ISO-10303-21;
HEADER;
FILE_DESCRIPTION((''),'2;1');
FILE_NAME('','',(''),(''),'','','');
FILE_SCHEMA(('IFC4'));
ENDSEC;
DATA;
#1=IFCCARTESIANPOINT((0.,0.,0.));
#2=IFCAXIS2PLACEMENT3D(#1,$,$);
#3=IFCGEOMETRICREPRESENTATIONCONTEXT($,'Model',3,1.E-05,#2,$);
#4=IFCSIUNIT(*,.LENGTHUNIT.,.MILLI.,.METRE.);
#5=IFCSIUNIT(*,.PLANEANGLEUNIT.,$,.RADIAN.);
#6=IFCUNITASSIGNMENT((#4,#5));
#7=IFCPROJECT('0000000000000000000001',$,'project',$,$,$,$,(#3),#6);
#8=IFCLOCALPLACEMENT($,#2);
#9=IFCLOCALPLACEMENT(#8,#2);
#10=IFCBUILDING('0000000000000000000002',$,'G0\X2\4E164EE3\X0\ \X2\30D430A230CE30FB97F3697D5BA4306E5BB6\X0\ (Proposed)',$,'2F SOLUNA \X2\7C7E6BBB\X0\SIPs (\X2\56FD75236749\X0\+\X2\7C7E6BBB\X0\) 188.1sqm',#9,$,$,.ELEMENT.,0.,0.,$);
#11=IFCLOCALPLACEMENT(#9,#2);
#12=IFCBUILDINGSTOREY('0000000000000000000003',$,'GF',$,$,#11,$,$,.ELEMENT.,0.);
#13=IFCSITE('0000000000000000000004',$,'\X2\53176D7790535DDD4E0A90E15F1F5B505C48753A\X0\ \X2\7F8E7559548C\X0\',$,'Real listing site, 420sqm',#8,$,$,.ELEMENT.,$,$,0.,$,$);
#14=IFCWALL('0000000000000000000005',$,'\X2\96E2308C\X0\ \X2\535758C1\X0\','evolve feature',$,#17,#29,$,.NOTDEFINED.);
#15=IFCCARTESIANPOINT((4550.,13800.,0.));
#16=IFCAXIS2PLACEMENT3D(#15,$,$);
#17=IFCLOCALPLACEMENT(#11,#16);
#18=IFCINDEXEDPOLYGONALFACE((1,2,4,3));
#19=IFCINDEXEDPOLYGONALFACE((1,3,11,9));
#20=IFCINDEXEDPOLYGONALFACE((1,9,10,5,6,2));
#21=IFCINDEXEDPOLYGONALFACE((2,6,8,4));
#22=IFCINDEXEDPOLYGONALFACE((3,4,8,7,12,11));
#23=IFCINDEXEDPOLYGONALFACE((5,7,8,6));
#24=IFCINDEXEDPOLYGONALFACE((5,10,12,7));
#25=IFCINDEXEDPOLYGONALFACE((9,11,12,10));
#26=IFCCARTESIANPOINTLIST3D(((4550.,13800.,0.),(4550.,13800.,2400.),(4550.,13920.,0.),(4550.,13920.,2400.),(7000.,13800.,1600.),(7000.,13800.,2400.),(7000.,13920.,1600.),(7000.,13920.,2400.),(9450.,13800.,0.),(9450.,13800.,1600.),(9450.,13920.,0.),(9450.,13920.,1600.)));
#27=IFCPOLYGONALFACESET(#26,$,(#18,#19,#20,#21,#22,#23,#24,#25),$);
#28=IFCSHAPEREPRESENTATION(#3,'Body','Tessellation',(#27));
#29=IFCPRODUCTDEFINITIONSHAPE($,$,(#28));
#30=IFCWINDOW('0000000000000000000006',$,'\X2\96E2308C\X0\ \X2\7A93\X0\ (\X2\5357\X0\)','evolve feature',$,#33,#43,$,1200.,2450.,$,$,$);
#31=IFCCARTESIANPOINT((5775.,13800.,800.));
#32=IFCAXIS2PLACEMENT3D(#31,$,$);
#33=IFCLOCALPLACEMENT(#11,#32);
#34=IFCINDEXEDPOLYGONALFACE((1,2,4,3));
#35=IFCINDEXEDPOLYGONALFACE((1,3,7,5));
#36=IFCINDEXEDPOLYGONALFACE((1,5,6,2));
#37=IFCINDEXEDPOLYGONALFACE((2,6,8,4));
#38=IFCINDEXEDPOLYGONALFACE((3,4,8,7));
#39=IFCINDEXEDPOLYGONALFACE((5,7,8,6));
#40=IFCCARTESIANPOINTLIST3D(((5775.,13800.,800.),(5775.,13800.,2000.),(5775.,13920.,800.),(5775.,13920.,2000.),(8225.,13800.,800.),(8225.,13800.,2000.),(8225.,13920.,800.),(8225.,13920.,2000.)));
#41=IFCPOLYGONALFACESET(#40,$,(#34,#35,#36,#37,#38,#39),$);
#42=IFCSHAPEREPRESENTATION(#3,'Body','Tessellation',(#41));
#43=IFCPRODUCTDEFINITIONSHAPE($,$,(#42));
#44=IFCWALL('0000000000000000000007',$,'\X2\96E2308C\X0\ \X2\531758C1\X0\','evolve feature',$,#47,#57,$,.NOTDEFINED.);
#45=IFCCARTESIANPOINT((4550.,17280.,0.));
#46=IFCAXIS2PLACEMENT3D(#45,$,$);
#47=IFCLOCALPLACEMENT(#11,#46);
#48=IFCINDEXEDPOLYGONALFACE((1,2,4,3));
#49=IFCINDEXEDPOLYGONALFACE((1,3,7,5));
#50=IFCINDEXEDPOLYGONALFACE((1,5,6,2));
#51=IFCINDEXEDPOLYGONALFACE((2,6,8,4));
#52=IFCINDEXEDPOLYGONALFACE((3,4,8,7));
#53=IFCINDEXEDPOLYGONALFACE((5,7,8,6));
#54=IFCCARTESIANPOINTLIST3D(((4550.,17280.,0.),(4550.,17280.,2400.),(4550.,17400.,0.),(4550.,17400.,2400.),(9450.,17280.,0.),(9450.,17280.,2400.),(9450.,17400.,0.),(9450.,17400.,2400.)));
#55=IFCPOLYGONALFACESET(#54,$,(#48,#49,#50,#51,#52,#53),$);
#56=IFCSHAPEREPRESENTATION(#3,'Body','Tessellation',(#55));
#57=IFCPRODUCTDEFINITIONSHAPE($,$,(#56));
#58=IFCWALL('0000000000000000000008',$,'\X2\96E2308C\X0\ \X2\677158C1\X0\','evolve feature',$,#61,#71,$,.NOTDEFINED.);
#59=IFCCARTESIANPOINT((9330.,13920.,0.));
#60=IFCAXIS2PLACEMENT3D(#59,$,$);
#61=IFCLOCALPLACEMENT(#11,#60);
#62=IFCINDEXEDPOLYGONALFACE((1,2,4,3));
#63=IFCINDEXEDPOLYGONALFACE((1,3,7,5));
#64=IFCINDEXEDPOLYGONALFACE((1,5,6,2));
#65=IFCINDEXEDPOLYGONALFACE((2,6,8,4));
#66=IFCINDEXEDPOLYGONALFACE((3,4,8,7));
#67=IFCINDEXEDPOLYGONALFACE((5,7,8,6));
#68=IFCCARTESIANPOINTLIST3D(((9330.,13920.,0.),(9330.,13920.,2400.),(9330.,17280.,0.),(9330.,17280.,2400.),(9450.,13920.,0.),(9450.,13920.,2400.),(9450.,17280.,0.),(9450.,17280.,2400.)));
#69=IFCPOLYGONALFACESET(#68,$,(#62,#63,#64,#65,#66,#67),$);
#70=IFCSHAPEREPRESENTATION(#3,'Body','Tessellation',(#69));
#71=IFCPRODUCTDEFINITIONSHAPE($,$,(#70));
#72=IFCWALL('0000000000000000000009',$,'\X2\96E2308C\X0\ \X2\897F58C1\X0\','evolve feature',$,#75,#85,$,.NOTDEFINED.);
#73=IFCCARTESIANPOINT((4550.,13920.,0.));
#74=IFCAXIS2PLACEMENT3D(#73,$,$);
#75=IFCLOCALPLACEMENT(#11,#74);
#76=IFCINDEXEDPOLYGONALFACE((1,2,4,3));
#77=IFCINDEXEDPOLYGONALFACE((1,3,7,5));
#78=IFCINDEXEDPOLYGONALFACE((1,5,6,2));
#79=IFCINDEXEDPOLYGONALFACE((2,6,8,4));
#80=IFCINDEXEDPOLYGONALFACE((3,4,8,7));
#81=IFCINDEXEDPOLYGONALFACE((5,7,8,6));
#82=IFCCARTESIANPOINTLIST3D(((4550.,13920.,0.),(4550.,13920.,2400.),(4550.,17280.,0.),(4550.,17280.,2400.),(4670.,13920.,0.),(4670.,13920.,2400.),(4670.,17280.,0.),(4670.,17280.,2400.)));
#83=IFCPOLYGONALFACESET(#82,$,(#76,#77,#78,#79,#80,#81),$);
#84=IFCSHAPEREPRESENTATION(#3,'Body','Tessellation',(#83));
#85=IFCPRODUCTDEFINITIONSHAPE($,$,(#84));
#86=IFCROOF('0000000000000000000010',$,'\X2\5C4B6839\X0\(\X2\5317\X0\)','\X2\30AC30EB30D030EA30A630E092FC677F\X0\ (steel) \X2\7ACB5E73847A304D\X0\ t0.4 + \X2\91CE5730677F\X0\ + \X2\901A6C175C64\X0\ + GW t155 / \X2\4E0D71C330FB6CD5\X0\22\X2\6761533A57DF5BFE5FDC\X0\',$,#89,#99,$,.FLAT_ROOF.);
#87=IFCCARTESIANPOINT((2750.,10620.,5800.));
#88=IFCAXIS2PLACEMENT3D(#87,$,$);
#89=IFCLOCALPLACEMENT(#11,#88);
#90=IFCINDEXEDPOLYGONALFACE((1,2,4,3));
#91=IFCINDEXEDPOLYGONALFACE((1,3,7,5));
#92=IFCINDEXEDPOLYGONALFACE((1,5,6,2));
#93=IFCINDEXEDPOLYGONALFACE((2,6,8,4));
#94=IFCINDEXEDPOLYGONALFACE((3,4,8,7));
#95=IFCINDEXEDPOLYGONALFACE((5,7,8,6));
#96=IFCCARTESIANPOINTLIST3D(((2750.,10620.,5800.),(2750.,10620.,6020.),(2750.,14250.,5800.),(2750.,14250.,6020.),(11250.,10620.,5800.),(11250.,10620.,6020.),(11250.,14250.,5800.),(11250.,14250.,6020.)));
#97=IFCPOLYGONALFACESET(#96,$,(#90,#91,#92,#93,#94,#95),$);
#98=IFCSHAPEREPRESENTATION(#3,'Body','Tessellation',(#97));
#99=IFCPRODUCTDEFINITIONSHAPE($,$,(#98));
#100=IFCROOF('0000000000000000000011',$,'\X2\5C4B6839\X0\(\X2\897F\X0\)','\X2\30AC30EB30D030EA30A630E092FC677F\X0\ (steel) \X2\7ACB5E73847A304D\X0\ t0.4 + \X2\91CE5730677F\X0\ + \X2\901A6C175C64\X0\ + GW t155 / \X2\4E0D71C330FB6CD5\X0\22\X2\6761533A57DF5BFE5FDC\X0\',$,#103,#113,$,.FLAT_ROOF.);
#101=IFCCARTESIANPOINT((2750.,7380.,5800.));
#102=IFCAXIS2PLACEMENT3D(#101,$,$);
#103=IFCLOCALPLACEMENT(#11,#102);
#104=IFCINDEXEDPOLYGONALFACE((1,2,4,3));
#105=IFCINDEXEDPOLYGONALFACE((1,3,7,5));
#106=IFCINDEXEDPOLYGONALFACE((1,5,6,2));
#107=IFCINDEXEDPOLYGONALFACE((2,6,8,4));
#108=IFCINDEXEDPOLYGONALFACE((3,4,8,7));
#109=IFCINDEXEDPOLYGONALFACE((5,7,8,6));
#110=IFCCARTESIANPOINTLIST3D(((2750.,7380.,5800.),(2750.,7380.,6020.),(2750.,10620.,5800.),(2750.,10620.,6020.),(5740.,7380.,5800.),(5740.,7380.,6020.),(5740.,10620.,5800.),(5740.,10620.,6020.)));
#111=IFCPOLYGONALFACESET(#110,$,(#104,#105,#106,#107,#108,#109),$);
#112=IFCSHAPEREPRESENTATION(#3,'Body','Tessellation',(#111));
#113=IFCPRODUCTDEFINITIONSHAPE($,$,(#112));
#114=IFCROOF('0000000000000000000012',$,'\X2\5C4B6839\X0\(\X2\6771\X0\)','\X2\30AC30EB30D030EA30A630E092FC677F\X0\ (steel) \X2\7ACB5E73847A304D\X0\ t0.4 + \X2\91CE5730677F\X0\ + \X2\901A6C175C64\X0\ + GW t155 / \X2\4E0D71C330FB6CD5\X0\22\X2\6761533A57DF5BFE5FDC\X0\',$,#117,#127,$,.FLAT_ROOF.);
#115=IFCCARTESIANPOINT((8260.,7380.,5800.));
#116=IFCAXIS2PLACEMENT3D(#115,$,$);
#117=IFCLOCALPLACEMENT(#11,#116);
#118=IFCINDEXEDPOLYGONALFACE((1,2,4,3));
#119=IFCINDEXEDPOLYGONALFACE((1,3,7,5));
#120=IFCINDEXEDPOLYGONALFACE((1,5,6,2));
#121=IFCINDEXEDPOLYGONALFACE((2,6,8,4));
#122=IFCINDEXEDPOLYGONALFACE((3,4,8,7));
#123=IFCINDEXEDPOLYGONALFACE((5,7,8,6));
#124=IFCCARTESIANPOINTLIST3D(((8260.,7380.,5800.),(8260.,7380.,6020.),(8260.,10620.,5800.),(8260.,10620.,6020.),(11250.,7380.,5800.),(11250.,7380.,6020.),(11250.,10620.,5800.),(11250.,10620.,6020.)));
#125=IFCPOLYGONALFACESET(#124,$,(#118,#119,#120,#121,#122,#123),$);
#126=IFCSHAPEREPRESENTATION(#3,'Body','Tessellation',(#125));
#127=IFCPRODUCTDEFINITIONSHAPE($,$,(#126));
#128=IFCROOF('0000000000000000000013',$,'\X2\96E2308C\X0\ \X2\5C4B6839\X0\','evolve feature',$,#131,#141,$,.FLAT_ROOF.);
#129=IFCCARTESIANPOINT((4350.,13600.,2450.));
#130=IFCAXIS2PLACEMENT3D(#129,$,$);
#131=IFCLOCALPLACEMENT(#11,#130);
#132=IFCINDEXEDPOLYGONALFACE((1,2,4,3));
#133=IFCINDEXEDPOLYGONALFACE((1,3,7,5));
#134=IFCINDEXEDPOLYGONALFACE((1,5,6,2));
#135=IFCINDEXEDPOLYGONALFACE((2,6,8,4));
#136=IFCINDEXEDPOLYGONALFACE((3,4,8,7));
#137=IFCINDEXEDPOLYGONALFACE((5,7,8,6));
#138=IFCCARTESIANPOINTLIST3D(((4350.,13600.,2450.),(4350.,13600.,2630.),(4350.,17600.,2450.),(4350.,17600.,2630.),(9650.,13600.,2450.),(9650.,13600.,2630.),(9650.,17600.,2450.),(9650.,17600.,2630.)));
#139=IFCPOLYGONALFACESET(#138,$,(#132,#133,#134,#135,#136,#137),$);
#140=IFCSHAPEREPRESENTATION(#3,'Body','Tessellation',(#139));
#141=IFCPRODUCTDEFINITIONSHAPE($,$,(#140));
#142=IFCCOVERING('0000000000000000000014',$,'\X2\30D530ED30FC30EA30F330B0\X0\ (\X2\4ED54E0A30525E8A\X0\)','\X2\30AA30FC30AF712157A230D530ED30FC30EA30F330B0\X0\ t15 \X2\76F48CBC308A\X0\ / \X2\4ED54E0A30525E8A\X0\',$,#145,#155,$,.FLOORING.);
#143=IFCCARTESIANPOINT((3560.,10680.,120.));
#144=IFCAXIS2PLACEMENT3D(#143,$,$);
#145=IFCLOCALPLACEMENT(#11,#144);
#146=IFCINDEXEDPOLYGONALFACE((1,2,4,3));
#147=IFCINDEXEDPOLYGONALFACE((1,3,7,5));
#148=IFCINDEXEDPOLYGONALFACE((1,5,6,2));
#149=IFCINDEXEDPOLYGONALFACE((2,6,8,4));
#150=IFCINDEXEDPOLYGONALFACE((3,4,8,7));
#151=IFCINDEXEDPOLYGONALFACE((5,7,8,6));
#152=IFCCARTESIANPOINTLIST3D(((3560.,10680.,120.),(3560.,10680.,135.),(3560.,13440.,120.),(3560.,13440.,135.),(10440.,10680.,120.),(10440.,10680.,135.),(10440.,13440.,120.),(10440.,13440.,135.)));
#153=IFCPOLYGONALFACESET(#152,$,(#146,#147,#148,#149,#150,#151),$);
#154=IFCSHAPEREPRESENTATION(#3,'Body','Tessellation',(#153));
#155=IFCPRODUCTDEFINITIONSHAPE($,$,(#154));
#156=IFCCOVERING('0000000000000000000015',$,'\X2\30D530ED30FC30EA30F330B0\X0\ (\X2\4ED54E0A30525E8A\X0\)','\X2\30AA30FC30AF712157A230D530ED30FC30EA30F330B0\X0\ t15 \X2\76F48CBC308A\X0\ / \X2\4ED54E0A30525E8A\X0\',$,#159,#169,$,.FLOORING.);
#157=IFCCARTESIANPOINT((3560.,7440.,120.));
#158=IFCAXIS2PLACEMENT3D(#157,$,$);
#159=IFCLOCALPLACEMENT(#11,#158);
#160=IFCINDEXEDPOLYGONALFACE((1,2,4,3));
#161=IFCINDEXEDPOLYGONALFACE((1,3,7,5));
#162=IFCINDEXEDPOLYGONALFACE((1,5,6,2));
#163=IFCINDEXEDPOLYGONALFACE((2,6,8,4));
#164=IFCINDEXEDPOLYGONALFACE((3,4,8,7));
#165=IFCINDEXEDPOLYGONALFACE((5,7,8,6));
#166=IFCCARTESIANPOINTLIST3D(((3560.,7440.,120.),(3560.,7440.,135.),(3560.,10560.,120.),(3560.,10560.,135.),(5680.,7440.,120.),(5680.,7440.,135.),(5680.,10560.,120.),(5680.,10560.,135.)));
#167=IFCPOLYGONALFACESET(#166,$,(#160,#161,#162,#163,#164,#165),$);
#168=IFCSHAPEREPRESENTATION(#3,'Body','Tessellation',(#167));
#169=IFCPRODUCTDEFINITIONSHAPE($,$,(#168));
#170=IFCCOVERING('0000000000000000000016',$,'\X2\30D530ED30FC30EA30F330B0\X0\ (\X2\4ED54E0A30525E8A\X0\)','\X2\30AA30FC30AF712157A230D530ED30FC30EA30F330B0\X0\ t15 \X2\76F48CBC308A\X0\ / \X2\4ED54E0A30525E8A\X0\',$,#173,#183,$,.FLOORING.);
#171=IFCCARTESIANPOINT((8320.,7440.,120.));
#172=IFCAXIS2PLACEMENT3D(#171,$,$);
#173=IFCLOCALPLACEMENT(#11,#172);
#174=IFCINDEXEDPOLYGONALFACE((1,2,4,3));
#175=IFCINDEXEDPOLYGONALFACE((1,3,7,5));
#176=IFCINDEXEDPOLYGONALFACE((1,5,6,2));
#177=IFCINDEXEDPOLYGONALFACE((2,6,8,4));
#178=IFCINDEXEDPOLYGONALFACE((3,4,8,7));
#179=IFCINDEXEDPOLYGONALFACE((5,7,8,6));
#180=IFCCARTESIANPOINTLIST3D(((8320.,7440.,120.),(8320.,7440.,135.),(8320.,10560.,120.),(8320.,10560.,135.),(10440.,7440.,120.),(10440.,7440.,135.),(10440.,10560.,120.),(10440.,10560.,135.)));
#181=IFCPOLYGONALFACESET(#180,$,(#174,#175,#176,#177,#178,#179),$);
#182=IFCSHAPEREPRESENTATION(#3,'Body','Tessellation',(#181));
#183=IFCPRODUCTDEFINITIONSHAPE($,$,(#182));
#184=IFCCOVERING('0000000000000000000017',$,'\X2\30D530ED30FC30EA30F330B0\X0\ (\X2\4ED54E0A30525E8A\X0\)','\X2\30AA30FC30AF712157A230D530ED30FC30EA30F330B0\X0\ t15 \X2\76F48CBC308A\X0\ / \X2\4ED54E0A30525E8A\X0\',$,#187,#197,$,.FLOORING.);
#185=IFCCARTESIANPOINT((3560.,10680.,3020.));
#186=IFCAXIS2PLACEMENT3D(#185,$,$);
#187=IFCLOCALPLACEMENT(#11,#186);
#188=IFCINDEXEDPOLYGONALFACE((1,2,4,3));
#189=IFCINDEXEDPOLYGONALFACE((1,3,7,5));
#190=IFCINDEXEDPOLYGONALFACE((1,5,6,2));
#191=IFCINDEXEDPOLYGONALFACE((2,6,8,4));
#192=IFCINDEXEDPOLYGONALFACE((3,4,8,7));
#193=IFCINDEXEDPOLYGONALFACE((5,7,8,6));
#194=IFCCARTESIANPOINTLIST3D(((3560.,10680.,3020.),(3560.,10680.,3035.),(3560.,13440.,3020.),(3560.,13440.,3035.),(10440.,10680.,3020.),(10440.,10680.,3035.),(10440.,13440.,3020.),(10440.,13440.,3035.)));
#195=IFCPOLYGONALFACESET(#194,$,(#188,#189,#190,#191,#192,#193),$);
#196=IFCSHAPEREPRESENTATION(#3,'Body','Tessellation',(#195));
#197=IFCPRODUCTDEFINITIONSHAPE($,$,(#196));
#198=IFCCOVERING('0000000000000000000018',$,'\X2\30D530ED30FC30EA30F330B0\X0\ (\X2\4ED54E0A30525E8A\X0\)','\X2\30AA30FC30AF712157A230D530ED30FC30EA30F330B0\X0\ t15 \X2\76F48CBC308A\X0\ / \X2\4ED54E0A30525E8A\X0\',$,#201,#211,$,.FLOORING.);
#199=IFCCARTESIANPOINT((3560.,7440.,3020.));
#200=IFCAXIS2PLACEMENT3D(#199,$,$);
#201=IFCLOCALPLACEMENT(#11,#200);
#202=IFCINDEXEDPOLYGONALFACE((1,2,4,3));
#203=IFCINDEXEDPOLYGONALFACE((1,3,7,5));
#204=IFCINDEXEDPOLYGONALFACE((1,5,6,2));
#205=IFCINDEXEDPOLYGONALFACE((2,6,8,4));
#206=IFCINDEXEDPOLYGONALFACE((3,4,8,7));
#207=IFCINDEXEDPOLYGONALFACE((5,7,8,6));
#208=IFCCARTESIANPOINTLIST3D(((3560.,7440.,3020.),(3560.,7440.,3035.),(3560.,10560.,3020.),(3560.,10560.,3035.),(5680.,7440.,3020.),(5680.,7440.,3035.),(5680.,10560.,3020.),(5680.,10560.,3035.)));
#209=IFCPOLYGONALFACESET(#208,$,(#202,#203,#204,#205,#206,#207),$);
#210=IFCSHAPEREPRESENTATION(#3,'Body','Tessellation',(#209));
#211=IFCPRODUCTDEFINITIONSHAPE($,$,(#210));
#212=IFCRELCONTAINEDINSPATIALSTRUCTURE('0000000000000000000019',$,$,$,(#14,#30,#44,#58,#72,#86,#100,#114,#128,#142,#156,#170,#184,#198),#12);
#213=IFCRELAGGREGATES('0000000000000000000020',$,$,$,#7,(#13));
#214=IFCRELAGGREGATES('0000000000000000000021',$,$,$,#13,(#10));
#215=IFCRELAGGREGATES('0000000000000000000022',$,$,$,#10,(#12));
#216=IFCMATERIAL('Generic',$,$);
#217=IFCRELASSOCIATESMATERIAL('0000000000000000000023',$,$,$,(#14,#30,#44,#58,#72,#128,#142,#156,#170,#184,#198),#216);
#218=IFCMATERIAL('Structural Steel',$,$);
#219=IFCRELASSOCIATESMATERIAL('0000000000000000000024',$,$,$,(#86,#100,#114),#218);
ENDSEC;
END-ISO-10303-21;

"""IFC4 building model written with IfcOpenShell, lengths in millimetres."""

from ifc_helpers import new_model, si_unit, frame, frame_2d, origin, place, context, project, spatial, rectangle, extrude, material, element, fill, save


model = new_model("IFC4")

# Units and contexts
model_context = context("Model", 3, precision=1e-05, world=origin())
ifc_project = project(units=[si_unit("LENGTHUNIT", "METRE", prefix="MILLI"), si_unit("PLANEANGLEUNIT", "RADIAN")], contexts=[model_context])

# Site, building, storey
site_placement = place(None, origin())
site = spatial("IfcSite", under=ifc_project, at=site_placement, Name="北海道川上郡弟子屈町 美留和", ObjectType="Real listing site, 420sqm", CompositionType="ELEMENT", RefElevation=0.0)
building_placement = place(site_placement, origin())
building = spatial("IfcBuilding", under=site, at=building_placement, Name="G0世代 ピアノ・音楽室の家 (Proposed)", ObjectType="2F SOLUNA 籾殻SIPs (国産杉+籾殻) 188.1sqm", CompositionType="ELEMENT", ElevationOfRefHeight=0.0, ElevationOfTerrain=0.0)
storey_placement = place(building_placement, origin())
storey = spatial("IfcBuildingStorey", under=building, at=storey_placement, Name="GF", CompositionType="ELEMENT", Elevation=0.0)

# Shared definitions
ifc_material_1 = material(Name="Generic")

# Wall, opening, window
wall_1_placement = place(storey_placement, frame((4550.0, 13800.0, 0.0)))
wall_1 = element("IfcWall", 1, at=wall_1_placement, inside=storey, material=ifc_material_1, Name="離れ 南壁", Description="evolve feature", PredefinedType="NOTDEFINED", context=model_context, shape_type="SweptSolid", body=[
    extrude(rectangle(XDim=4900.0, YDim=120.0, at=frame_2d((2450.0, 60.0))), frame((4550.0, 13800.0, 0.0)), (0.0, 0.0, 1.0), 2400.0),
])
opening_1_placement = place(storey_placement, frame((5775.0, 13800.0, 800.0)))
opening_1 = element("IfcOpeningElement", 2, at=opening_1_placement, cuts=wall_1, PredefinedType="NOTDEFINED", context=model_context, shape_type="SweptSolid", body=[
    extrude(rectangle(XDim=2450.0, YDim=120.0, at=frame_2d((1225.0, 60.0))), frame((5775.0, 13800.0, 800.0)), (0.0, 0.0, 1.0), 1200.0),
])
window_1_placement = place(storey_placement, frame((5775.0, 13800.0, 800.0)))
window_1 = element("IfcWindow", 3, at=window_1_placement, inside=storey, material=ifc_material_1, Name="離れ 窓 (南)", Description="evolve feature", OverallHeight=1200.0, OverallWidth=2450.0, context=model_context, shape_type="SweptSolid", body=[
    extrude(rectangle(XDim=2450.0, YDim=120.0, at=frame_2d((1225.0, 60.0))), frame((5775.0, 13800.0, 800.0)), (0.0, 0.0, 1.0), 1200.0),
])
fill(opening_1, window_1)

# Walls
wall_2_placement = place(storey_placement, frame((4550.0, 17280.0, 0.0)))
element("IfcWall", 4, at=wall_2_placement, inside=storey, material=ifc_material_1, Name="離れ 北壁", Description="evolve feature", PredefinedType="NOTDEFINED", context=model_context, shape_type="SweptSolid", body=[
    extrude(rectangle(XDim=4900.0, YDim=120.0, at=frame_2d((2450.0, 60.0))), frame((4550.0, 17280.0, 0.0)), (0.0, 0.0, 1.0), 2400.0),
])
wall_3_placement = place(storey_placement, frame((9330.0, 13920.0, 0.0)))
element("IfcWall", 5, at=wall_3_placement, inside=storey, material=ifc_material_1, Name="離れ 東壁", Description="evolve feature", PredefinedType="NOTDEFINED", context=model_context, shape_type="SweptSolid", body=[
    extrude(rectangle(XDim=120.0, YDim=3360.0, at=frame_2d((60.0, 1680.0))), frame((9330.0, 13920.0, 0.0)), (0.0, 0.0, 1.0), 2400.0),
])
wall_4_placement = place(storey_placement, frame((4550.0, 13920.0, 0.0)))
element("IfcWall", 6, at=wall_4_placement, inside=storey, material=ifc_material_1, Name="離れ 西壁", Description="evolve feature", PredefinedType="NOTDEFINED", context=model_context, shape_type="SweptSolid", body=[
    extrude(rectangle(XDim=120.0, YDim=3360.0, at=frame_2d((60.0, 1680.0))), frame((4550.0, 13920.0, 0.0)), (0.0, 0.0, 1.0), 2400.0),
])

# Roofs
ifc_material_2 = material(Name="Structural Steel")
for number, where, name in (
    (7, (2750.0, 10620.0, 5800.0), "屋根(北)"),
):
    element("IfcRoof", number, at=place(storey_placement, frame(where)), inside=storey, material=ifc_material_2, Name=name, Description="ガルバリウム鋼板 (steel) 立平葺き t0.4 + 野地板 + 通気層 + GW t155 / 不燃・法22条区域対応", PredefinedType="FLAT_ROOF", context=model_context, shape_type="SweptSolid", body=[
        extrude(rectangle(XDim=8500.0, YDim=3630.0, at=frame_2d((4250.0, 1815.0))), frame((2750.0, 10620.0, 5800.0)), (0.0, 0.0, 1.0), 220.0),
    ])
roof_1_placement = place(storey_placement, frame((2750.0, 7380.0, 5800.0)))
element("IfcRoof", 8, at=roof_1_placement, inside=storey, material=ifc_material_2, Name="屋根(西)", Description="ガルバリウム鋼板 (steel) 立平葺き t0.4 + 野地板 + 通気層 + GW t155 / 不燃・法22条区域対応", PredefinedType="FLAT_ROOF", context=model_context, shape_type="SweptSolid", body=[
    extrude(rectangle(XDim=2990.0, YDim=3240.0, at=frame_2d((1495.0, 1620.0))), frame((2750.0, 7380.0, 5800.0)), (0.0, 0.0, 1.0), 220.0),
])
roof_2_placement = place(storey_placement, frame((8260.0, 7380.0, 5800.0)))
element("IfcRoof", 9, at=roof_2_placement, inside=storey, material=ifc_material_2, Name="屋根(東)", Description="ガルバリウム鋼板 (steel) 立平葺き t0.4 + 野地板 + 通気層 + GW t155 / 不燃・法22条区域対応", PredefinedType="FLAT_ROOF", context=model_context, shape_type="SweptSolid", body=[
    extrude(rectangle(XDim=2990.0, YDim=3240.0, at=frame_2d((1495.0, 1620.0))), frame((8260.0, 7380.0, 5800.0)), (0.0, 0.0, 1.0), 220.0),
])
roof_3_placement = place(storey_placement, frame((4350.0, 13600.0, 2450.0)))
element("IfcRoof", 10, at=roof_3_placement, inside=storey, material=ifc_material_1, Name="離れ 屋根", Description="evolve feature", PredefinedType="FLAT_ROOF", context=model_context, shape_type="SweptSolid", body=[
    extrude(rectangle(XDim=5300.0, YDim=4000.0, at=frame_2d((2650.0, 2000.0))), frame((4350.0, 13600.0, 2450.0)), (0.0, 0.0, 1.0), 180.0),
])

# Coverings
covering_1_placement = place(storey_placement, frame((3560.0, 10680.0, 120.0)))
element("IfcCovering", 11, at=covering_1_placement, inside=storey, material=ifc_material_1, Name="フローリング (仕上げ床)", Description="オーク無垢フローリング t15 直貼り / 仕上げ床", PredefinedType="FLOORING", context=model_context, shape_type="SweptSolid", body=[
    extrude(rectangle(XDim=6880.0, YDim=2760.0, at=frame_2d((3440.0, 1380.0))), frame((3560.0, 10680.0, 120.0)), (0.0, 0.0, 1.0), 15.0),
])
covering_2_placement = place(storey_placement, frame((3560.0, 7440.0, 120.0)))
element("IfcCovering", 12, at=covering_2_placement, inside=storey, material=ifc_material_1, Name="フローリング (仕上げ床)", Description="オーク無垢フローリング t15 直貼り / 仕上げ床", PredefinedType="FLOORING", context=model_context, shape_type="SweptSolid", body=[
    extrude(rectangle(XDim=2120.0, YDim=3120.0, at=frame_2d((1060.0, 1560.0))), frame((3560.0, 7440.0, 120.0)), (0.0, 0.0, 1.0), 15.0),
])
covering_3_placement = place(storey_placement, frame((8320.0, 7440.0, 120.0)))
element("IfcCovering", 13, at=covering_3_placement, inside=storey, material=ifc_material_1, Name="フローリング (仕上げ床)", Description="オーク無垢フローリング t15 直貼り / 仕上げ床", PredefinedType="FLOORING", context=model_context, shape_type="SweptSolid", body=[
    extrude(rectangle(XDim=2120.0, YDim=3120.0, at=frame_2d((1060.0, 1560.0))), frame((8320.0, 7440.0, 120.0)), (0.0, 0.0, 1.0), 15.0),
])
covering_4_placement = place(storey_placement, frame((3560.0, 10680.0, 3020.0)))
element("IfcCovering", 14, at=covering_4_placement, inside=storey, material=ifc_material_1, Name="フローリング (仕上げ床)", Description="オーク無垢フローリング t15 直貼り / 仕上げ床", PredefinedType="FLOORING", context=model_context, shape_type="SweptSolid", body=[
    extrude(rectangle(XDim=6880.0, YDim=2760.0, at=frame_2d((3440.0, 1380.0))), frame((3560.0, 10680.0, 3020.0)), (0.0, 0.0, 1.0), 15.0),
])
covering_5_placement = place(storey_placement, frame((3560.0, 7440.0, 3020.0)))
element("IfcCovering", 15, at=covering_5_placement, inside=storey, material=ifc_material_1, Name="フローリング (仕上げ床)", Description="オーク無垢フローリング t15 直貼り / 仕上げ床", PredefinedType="FLOORING", context=model_context, shape_type="SweptSolid", body=[
    extrude(rectangle(XDim=2120.0, YDim=3120.0, at=frame_2d((1060.0, 1560.0))), frame((3560.0, 7440.0, 3020.0)), (0.0, 0.0, 1.0), 15.0),
])

save(model, "model.ifc")
